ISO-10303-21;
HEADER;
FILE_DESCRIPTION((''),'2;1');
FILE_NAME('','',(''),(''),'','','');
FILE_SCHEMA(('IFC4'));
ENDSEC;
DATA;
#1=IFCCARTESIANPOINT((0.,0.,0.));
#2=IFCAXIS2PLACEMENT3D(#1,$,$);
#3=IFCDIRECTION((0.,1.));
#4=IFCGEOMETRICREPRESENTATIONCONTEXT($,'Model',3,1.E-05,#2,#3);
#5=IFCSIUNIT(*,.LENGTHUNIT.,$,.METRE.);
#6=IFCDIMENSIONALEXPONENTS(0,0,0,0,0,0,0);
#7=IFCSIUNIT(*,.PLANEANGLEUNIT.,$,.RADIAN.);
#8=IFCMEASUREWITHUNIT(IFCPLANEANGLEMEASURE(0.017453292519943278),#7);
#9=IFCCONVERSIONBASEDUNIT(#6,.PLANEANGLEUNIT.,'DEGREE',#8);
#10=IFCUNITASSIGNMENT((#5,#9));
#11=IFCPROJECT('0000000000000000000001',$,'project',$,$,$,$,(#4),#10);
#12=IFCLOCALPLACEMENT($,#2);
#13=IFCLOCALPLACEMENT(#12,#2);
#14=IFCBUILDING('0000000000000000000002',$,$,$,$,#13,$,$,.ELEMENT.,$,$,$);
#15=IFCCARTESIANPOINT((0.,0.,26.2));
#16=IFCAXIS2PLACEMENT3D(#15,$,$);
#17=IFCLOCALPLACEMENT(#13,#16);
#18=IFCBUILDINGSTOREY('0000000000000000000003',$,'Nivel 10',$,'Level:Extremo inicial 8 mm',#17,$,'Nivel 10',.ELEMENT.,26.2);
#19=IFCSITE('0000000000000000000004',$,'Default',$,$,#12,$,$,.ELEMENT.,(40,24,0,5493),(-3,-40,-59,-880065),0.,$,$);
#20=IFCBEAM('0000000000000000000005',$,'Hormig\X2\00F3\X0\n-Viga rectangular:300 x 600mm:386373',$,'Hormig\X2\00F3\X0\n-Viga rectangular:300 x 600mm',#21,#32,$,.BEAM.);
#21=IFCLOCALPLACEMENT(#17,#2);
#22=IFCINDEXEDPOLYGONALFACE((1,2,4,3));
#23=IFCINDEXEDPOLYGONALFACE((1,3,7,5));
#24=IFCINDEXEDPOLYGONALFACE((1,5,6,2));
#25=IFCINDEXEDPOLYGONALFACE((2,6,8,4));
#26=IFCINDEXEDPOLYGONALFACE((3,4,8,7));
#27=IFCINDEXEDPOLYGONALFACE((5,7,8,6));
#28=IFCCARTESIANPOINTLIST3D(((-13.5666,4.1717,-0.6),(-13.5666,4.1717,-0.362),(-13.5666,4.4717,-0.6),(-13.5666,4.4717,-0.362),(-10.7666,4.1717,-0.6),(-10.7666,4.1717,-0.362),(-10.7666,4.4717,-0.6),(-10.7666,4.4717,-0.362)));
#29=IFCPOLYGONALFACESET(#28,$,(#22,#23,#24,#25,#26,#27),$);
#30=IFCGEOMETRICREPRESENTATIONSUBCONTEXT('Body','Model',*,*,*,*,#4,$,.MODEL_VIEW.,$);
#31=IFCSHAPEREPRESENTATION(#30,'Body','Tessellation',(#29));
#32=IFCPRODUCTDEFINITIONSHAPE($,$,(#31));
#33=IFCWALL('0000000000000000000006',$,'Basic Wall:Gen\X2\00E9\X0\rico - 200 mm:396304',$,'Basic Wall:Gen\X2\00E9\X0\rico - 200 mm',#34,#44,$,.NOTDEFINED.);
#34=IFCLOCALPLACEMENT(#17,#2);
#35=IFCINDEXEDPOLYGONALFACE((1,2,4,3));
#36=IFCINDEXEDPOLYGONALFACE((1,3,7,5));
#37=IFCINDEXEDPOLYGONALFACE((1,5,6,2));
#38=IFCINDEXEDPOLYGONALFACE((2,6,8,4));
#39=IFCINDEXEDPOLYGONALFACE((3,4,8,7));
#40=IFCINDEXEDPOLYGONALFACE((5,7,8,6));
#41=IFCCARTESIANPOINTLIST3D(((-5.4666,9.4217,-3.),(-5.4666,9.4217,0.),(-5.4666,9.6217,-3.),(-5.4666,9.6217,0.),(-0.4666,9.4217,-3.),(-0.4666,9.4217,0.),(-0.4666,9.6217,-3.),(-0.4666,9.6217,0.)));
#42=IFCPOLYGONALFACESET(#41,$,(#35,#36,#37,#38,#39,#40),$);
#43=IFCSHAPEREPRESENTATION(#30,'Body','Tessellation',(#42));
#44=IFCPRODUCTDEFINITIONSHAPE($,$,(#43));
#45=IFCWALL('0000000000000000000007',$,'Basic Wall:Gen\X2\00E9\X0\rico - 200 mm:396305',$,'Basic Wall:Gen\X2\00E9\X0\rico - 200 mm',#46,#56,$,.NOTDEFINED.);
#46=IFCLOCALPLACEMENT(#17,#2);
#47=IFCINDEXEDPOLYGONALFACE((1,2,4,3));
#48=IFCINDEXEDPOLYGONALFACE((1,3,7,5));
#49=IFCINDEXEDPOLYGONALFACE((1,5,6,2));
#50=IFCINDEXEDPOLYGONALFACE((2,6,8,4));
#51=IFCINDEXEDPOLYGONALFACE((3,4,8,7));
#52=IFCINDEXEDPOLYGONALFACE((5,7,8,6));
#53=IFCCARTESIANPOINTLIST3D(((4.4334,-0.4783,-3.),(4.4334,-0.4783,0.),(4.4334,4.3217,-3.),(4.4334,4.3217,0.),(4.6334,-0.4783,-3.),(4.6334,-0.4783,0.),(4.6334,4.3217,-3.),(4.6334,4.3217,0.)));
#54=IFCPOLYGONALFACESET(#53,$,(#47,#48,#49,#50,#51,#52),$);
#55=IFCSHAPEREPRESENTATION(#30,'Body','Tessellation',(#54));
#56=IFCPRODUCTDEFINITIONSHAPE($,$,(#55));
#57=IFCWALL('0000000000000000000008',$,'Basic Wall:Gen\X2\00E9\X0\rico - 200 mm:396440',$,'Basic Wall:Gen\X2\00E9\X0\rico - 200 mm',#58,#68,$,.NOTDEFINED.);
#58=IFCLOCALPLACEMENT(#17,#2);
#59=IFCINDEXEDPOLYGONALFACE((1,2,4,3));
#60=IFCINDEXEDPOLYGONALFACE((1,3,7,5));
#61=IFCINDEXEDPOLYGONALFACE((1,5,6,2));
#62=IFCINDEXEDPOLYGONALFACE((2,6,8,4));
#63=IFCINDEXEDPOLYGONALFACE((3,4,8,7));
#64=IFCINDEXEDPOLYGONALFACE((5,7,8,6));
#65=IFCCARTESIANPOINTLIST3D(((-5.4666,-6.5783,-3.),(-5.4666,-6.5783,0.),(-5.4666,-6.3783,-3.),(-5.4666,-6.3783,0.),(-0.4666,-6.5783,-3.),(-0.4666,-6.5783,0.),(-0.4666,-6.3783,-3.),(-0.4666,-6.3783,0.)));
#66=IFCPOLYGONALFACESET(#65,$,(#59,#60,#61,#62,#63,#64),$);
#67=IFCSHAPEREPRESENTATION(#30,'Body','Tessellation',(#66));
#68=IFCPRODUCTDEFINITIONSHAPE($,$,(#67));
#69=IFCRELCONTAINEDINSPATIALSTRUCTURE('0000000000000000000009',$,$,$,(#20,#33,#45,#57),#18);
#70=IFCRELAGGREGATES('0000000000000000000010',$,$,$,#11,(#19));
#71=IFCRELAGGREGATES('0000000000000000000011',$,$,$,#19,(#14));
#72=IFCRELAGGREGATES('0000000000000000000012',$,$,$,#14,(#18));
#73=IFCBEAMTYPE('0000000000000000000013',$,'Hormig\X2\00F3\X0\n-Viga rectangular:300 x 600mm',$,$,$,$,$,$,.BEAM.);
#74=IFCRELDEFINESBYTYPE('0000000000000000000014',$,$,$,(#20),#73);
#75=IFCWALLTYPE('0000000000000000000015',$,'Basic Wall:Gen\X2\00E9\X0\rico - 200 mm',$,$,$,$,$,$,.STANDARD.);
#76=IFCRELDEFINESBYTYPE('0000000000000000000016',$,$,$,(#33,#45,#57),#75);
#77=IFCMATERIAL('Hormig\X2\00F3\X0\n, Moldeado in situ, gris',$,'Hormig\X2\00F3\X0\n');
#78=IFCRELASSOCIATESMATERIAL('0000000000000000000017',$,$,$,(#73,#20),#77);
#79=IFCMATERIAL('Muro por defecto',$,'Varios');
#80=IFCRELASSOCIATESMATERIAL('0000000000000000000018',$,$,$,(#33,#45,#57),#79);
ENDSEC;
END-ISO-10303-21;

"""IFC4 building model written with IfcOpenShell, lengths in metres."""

from ifc_helpers import new_model, entity, si_unit, converted_unit, direction, frame, origin, place, context, subcontext, project, spatial, indexed_curve, outline, extrude, source, transform, mapped, material, type_object, type_shapes, element, save


model = new_model("IFC4")

# Units and contexts
model_context = context("Model", 3, precision=1e-05, world=origin(), true_north=direction((0.0, 1.0)))
body_context = subcontext(model_context, "Body", "Model", "MODEL_VIEW")
ifc_project = project(units=[si_unit("LENGTHUNIT", "METRE"), converted_unit("PLANEANGLEUNIT", "DEGREE", entity("IfcPlaneAngleMeasure", 0.017453292519943278), si_unit("PLANEANGLEUNIT", "RADIAN"), dimensions=[0, 0, 0, 0, 0, 0, 0])], contexts=[model_context])

# Site, building, storey
site_placement = place(None, origin())
site = spatial("IfcSite", under=ifc_project, at=site_placement, Name="Default", CompositionType="ELEMENT", RefLatitude=(40, 24, 0, 5493), RefLongitude=(-3, -40, -59, -880065), RefElevation=0.0)
building_placement = place(site_placement, origin())
building = spatial("IfcBuilding", under=site, at=building_placement, CompositionType="ELEMENT")
storey_placement = place(building_placement, frame((0.0, 0.0, 26.2)))
storey = spatial("IfcBuildingStorey", under=building, at=storey_placement, Name="Nivel 10", ObjectType="Level:Extremo inicial 8 mm", LongName="Nivel 10", CompositionType="ELEMENT", Elevation=26.2)

# Shared definitions
ifc_material_1 = material(Name="Hormigón, Moldeado in situ, gris", Category="Hormigón")

# Beam
beam_type_1 = type_object("IfcBeamType", Name="Hormigón-Viga rectangular:300 x 600mm", PredefinedType="BEAM", material=ifc_material_1)
shared_shape_1 = source(origin(), body_context, "Body", "SweptSolid", [
    extrude(outline(indexed_curve([(-0.119, -0.15), (0.119, -0.15), (0.119, 0.15), (-0.119, 0.15), (-0.119, -0.15)], self_intersect=False)), frame((-10.7666, 4.3217, 25.719), z_axis=(-1.0, 0.0, 0.0), x_axis=(0.0, 0.0, -1.0)), (0.0, 0.0, 1.0), 2.8),
])
type_shapes(beam_type_1, [shared_shape_1])
beam_1_placement = place(storey_placement, frame((0.0, 0.0, -26.2)))
element("IfcBeam", 1, at=beam_1_placement, inside=storey, type_object=beam_type_1, material=ifc_material_1, Name="Hormigón-Viga rectangular:300 x 600mm:386373", ObjectType="Hormigón-Viga rectangular:300 x 600mm", PredefinedType="BEAM", context=body_context, shape_type="MappedRepresentation", body=[
    mapped(shared_shape_1, transform((0.0, 0.0, 0.0), scale=1.0)),
])

# Walls
ifc_material_2 = material(Name="Muro por defecto", Category="Varios")
wall_type = type_object("IfcWallType", Name="Basic Wall:Genérico - 200 mm", PredefinedType="STANDARD")
wall_1_placement = place(storey_placement, frame((-5.4666, 9.5217, -3.0)))
element("IfcWall", 2, at=wall_1_placement, inside=storey, type_object=wall_type, material=ifc_material_2, Name="Basic Wall:Genérico - 200 mm:396304", ObjectType="Basic Wall:Genérico - 200 mm", PredefinedType="NOTDEFINED", context=body_context, shape_type="SweptSolid", body=[
    extrude(outline(indexed_curve([(5.0, 0.1), (0.0, 0.1), (0.0, -0.1), (5.0, -0.1), (5.0, 0.1)], self_intersect=False)), origin(), (0.0, 0.0, 1.0), 3.0),
])
wall_2_placement = place(storey_placement, frame((4.5334, 4.3217, -3.0), z_axis=(0.0, 0.0, 1.0), x_axis=(0.0, -1.0, 0.0)))
element("IfcWall", 3, at=wall_2_placement, inside=storey, type_object=wall_type, material=ifc_material_2, Name="Basic Wall:Genérico - 200 mm:396305", ObjectType="Basic Wall:Genérico - 200 mm", PredefinedType="NOTDEFINED", context=body_context, shape_type="SweptSolid", body=[
    extrude(outline(indexed_curve([(4.8, 0.1), (0.0, 0.1), (0.0, -0.1), (4.8, -0.1), (4.8, 0.1)], self_intersect=False)), origin(), (0.0, 0.0, 1.0), 3.0),
])
wall_3_placement = place(storey_placement, frame((-5.4666, -6.4783, -3.0)))
element("IfcWall", 4, at=wall_3_placement, inside=storey, type_object=wall_type, material=ifc_material_2, Name="Basic Wall:Genérico - 200 mm:396440", ObjectType="Basic Wall:Genérico - 200 mm", PredefinedType="NOTDEFINED", context=body_context, shape_type="SweptSolid", body=[
    extrude(outline(indexed_curve([(5.0, 0.1), (0.0, 0.1), (0.0, -0.1), (5.0, -0.1), (5.0, 0.1)], self_intersect=False)), origin(), (0.0, 0.0, 1.0), 3.0),
])

save(model, "model.ifc")
